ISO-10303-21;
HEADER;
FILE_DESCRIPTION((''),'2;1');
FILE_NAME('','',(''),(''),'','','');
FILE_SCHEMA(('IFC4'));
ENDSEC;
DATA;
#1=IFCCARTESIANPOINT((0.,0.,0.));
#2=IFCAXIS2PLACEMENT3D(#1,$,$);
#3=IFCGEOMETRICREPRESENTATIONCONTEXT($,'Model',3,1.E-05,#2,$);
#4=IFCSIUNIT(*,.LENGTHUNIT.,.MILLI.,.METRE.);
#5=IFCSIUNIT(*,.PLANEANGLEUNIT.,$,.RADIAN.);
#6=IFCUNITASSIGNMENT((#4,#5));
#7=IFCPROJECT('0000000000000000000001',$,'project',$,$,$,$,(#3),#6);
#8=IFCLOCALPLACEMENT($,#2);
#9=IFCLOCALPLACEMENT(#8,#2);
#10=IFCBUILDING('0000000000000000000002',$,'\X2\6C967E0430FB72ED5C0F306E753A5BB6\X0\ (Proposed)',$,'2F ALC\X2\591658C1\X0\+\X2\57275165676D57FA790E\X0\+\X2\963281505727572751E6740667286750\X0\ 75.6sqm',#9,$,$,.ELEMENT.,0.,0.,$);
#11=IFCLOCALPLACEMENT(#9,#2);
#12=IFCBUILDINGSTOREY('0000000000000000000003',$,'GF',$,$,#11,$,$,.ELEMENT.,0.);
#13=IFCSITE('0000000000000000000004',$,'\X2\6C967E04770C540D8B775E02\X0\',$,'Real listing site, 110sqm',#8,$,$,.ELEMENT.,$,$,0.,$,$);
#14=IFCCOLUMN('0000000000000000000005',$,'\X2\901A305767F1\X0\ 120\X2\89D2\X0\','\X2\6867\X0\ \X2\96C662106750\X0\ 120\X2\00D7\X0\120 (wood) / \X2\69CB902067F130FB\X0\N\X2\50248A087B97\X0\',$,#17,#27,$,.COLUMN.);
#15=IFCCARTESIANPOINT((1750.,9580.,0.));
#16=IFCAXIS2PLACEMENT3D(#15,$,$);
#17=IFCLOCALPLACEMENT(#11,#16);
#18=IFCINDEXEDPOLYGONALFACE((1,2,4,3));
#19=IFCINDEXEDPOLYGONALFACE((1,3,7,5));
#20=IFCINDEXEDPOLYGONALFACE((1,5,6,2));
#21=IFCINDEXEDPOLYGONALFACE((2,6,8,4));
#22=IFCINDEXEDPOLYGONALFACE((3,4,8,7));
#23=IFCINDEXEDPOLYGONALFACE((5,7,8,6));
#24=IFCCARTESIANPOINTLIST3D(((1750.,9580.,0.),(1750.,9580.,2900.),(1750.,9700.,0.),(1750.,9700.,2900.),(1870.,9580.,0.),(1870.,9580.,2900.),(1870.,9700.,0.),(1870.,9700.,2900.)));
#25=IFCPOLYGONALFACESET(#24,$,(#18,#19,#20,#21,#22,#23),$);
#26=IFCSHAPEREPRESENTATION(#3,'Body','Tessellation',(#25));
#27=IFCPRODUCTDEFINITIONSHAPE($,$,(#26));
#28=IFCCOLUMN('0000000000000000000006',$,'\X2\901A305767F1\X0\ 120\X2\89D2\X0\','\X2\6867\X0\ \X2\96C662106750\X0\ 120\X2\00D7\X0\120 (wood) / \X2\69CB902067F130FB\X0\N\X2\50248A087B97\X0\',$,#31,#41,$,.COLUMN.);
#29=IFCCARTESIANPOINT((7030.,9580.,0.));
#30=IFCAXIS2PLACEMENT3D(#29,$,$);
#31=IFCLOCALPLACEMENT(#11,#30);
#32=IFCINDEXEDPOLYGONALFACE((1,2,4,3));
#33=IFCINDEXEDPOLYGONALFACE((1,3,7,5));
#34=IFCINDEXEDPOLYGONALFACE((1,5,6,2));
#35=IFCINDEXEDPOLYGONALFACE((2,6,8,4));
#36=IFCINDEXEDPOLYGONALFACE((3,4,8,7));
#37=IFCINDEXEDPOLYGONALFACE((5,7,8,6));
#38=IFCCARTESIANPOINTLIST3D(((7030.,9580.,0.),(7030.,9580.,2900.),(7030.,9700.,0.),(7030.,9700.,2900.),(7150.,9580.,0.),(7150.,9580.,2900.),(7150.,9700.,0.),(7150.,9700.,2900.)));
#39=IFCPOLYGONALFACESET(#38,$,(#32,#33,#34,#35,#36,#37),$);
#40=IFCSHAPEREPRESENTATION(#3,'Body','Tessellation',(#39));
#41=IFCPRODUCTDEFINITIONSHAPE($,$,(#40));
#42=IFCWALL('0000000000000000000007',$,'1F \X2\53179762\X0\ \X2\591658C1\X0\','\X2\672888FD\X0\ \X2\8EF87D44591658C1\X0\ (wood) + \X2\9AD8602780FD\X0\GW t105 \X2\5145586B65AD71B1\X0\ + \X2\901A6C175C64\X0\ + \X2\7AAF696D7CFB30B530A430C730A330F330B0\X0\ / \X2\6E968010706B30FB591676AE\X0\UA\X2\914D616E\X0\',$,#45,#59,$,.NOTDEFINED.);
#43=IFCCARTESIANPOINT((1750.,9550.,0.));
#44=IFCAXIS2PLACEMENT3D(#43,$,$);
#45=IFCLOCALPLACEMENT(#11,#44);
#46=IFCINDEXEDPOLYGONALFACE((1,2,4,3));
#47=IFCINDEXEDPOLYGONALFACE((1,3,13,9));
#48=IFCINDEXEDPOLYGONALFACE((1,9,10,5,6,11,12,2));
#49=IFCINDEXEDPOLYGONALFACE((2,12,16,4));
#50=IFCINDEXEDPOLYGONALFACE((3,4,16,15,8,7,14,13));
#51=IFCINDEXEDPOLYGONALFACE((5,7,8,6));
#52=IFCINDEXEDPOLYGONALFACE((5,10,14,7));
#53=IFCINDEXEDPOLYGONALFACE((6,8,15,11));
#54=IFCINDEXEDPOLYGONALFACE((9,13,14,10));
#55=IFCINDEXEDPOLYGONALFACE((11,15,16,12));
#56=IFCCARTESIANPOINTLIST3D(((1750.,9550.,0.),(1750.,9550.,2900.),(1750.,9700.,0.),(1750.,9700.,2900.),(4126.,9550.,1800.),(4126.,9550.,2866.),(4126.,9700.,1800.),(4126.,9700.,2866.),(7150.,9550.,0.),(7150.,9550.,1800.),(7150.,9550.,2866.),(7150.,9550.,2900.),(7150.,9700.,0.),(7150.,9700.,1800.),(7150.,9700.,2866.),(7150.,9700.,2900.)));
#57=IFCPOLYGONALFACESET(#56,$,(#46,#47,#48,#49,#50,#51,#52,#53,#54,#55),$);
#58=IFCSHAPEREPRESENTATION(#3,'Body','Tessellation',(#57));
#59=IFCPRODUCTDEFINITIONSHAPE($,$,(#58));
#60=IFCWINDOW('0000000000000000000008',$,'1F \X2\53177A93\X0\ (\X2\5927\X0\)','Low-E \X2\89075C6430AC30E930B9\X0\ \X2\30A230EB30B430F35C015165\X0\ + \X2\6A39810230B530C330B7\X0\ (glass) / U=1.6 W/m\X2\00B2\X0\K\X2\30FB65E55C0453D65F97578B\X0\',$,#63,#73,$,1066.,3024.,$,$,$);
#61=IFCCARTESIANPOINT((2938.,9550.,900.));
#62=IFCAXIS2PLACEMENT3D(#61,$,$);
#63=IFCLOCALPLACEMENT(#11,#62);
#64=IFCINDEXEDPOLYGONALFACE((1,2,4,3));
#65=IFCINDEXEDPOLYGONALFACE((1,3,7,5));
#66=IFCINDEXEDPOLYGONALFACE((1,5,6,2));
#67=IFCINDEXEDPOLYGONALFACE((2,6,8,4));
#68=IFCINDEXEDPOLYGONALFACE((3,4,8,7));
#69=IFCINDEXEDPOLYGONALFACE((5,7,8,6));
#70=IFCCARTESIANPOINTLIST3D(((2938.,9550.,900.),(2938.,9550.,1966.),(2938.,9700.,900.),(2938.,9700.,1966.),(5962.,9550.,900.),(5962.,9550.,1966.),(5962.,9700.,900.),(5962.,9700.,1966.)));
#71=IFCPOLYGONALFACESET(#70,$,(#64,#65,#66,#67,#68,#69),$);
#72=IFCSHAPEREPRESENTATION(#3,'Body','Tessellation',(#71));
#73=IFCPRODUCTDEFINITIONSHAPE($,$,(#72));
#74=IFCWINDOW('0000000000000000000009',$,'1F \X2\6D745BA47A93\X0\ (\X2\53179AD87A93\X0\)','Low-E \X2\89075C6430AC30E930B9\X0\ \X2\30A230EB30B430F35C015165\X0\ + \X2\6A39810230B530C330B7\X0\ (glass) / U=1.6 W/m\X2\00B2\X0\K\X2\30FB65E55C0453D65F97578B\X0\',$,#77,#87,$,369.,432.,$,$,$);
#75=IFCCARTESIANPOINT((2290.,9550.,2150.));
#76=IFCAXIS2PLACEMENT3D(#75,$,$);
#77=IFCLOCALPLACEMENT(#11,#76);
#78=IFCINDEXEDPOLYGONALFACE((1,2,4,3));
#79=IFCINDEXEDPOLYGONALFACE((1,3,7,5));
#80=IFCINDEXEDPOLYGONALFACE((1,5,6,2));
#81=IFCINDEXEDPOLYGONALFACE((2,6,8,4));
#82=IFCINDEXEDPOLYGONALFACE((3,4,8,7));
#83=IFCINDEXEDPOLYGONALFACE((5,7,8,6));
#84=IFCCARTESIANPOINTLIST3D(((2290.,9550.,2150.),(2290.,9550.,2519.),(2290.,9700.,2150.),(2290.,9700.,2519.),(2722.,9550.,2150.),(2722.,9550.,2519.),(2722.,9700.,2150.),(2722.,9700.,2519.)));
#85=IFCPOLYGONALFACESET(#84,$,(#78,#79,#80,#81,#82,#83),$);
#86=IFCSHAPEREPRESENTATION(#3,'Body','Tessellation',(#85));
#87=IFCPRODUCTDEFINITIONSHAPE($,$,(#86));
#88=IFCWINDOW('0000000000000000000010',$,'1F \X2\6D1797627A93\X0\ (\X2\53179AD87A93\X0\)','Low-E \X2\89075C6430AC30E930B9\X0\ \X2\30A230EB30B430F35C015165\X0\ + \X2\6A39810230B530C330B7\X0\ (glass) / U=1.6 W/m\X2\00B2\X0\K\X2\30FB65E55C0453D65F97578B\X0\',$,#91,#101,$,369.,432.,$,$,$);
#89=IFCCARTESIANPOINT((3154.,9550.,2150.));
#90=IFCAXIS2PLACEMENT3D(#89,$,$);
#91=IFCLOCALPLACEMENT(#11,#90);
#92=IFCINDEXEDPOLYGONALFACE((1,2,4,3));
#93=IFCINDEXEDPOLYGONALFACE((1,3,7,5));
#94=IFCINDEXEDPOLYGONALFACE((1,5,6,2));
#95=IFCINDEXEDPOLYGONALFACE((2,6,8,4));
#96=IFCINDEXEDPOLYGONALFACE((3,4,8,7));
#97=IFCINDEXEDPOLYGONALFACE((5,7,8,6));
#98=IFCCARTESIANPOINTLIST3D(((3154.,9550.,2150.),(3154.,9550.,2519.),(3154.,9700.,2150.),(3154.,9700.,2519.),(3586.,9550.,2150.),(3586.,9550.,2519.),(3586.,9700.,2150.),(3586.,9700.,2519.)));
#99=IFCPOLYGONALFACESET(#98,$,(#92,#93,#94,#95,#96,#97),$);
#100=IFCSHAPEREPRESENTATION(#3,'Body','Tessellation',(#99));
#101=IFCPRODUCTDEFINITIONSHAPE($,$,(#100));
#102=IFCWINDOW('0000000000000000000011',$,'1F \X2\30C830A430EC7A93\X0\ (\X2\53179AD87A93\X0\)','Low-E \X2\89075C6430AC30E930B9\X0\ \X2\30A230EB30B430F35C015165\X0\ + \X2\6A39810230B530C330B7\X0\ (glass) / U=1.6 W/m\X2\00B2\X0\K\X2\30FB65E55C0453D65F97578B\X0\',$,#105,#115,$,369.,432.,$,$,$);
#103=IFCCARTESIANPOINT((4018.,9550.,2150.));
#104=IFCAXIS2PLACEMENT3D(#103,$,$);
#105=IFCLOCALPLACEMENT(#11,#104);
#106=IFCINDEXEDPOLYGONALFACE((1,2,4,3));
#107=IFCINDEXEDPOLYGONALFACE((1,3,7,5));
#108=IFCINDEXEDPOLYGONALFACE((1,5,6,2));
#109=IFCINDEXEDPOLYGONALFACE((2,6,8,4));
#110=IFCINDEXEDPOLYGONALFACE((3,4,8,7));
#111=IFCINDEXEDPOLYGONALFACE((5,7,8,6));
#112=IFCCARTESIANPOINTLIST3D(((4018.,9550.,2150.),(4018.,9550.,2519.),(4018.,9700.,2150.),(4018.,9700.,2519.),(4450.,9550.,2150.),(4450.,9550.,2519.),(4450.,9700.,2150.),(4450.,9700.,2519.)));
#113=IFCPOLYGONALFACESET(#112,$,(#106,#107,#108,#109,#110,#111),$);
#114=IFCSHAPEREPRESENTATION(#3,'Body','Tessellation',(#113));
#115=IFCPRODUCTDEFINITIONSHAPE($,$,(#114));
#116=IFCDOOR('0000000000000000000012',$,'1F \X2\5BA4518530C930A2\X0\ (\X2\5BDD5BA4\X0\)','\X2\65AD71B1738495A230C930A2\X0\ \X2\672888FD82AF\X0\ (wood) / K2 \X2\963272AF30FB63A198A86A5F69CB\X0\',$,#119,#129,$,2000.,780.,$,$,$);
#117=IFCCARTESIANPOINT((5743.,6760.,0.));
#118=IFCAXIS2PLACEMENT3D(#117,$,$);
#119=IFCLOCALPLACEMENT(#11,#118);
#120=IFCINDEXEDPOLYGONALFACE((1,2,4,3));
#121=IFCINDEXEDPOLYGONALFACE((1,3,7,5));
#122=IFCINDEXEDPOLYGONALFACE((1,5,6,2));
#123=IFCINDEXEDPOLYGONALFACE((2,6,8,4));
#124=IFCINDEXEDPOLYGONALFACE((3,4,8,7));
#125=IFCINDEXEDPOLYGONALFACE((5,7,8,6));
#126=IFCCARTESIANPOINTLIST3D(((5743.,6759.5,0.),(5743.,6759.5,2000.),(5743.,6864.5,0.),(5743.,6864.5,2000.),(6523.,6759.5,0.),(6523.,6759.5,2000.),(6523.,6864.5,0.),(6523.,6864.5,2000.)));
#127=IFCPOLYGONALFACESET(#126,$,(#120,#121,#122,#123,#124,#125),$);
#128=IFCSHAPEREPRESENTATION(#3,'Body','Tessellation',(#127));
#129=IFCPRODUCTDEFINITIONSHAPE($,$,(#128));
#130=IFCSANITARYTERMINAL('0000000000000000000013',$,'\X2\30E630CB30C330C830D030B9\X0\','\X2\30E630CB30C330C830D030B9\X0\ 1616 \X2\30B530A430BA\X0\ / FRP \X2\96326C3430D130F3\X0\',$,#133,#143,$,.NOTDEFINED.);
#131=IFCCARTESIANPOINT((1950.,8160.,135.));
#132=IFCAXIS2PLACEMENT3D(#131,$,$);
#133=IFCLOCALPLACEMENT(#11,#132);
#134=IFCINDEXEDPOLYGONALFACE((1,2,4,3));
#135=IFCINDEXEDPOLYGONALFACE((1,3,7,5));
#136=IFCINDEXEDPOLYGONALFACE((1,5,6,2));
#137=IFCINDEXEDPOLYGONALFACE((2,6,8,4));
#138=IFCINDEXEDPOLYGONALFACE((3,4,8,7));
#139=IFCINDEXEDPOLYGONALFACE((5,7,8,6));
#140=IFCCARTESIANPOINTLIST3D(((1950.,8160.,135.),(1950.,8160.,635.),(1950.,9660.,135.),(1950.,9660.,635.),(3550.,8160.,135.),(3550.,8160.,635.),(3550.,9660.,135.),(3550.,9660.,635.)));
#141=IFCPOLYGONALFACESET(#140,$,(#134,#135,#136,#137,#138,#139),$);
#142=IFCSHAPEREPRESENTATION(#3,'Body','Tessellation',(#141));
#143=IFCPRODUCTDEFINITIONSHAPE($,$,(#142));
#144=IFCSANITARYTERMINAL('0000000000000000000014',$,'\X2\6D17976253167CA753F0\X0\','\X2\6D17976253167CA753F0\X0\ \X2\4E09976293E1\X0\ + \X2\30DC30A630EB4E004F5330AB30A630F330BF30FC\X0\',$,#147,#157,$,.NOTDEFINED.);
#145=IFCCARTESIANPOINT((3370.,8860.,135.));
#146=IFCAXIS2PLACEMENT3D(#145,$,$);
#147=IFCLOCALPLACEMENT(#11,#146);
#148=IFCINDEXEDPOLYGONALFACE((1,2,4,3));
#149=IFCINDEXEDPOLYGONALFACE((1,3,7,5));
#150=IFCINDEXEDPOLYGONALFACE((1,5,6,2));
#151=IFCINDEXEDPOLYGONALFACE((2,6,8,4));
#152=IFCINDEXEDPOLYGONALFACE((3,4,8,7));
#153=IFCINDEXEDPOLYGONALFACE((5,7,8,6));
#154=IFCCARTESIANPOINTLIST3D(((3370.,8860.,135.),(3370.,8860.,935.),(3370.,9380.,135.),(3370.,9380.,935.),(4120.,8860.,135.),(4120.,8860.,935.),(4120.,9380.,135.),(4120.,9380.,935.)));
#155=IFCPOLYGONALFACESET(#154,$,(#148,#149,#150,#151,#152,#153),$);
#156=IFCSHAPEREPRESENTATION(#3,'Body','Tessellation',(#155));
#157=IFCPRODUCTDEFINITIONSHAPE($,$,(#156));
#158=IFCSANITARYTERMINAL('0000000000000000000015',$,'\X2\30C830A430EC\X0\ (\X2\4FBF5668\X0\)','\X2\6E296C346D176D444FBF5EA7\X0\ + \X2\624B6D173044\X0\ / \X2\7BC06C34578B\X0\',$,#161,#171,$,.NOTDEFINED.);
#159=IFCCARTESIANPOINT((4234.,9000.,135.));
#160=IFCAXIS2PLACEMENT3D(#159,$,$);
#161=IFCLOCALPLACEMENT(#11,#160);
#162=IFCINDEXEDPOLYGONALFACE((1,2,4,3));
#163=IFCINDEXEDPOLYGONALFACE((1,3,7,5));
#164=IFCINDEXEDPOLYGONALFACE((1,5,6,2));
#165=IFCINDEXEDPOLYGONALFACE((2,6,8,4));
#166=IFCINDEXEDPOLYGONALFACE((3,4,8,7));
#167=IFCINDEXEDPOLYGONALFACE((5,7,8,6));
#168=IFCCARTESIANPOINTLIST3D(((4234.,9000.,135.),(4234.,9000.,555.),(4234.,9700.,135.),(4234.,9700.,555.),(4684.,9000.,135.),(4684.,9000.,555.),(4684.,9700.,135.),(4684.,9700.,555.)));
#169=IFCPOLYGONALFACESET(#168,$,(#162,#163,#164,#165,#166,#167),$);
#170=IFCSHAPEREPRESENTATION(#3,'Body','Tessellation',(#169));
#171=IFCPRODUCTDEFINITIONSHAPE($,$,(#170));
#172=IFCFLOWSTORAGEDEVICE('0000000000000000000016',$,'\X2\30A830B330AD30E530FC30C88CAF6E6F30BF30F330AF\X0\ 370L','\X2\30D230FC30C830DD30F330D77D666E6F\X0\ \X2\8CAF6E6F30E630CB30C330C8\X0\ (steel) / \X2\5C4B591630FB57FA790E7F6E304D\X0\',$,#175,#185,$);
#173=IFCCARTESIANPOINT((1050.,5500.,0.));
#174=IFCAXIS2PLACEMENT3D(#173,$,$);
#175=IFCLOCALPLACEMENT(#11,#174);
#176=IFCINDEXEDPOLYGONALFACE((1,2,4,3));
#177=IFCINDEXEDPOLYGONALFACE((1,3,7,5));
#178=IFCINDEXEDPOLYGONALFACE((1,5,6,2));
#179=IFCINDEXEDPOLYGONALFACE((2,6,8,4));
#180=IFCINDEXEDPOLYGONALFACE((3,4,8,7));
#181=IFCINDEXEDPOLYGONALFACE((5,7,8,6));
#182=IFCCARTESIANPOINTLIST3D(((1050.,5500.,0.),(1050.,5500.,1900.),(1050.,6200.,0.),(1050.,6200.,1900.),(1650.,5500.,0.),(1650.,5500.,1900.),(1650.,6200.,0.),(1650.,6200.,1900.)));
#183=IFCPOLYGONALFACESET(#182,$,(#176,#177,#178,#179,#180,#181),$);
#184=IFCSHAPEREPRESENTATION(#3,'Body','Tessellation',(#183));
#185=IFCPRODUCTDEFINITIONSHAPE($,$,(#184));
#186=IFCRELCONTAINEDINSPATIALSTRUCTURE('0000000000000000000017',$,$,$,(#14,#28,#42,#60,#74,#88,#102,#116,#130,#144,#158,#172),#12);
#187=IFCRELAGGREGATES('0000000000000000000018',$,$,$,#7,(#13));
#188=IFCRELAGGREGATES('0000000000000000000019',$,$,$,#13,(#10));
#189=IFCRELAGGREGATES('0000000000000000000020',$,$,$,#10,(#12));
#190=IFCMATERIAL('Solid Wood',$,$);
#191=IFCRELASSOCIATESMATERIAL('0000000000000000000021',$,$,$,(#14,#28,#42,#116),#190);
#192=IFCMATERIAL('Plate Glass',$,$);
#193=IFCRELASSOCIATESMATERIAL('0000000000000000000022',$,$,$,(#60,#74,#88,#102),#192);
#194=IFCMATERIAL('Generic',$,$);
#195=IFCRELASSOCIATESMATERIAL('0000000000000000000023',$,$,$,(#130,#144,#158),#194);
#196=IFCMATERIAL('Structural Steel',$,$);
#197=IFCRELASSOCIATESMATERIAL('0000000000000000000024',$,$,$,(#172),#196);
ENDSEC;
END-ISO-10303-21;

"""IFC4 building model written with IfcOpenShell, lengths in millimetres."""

from ifc_helpers import new_model, si_unit, frame, frame_2d, origin, place, context, project, spatial, rectangle, extrude, material, element, fill, save


model = new_model("IFC4")

# Units and contexts
model_context = context("Model", 3, precision=1e-05, world=origin())
ifc_project = project(units=[si_unit("LENGTHUNIT", "METRE", prefix="MILLI"), si_unit("PLANEANGLEUNIT", "RADIAN")], contexts=[model_context])

# Site, building, storey
site_placement = place(None, origin())
site = spatial("IfcSite", under=ifc_project, at=site_placement, Name="沖縄県名護市", ObjectType="Real listing site, 110sqm", CompositionType="ELEMENT", RefElevation=0.0)
building_placement = place(site_placement, origin())
building = spatial("IfcBuilding", under=site, at=building_placement, Name="沖縄・狭小の町家 (Proposed)", ObjectType="2F ALC外壁+圧入杭基礎+防腐圧圧処理木材 75.6sqm", CompositionType="ELEMENT", ElevationOfRefHeight=0.0, ElevationOfTerrain=0.0)
storey_placement = place(building_placement, origin())
storey = spatial("IfcBuildingStorey", under=building, at=storey_placement, Name="GF", CompositionType="ELEMENT", Elevation=0.0)

# Columns
ifc_material_1 = material(Name="Solid Wood")
column_1_placement = place(storey_placement, frame((1750.0, 9580.0, 0.0)))
element("IfcColumn", 1, at=column_1_placement, inside=storey, material=ifc_material_1, Name="通し柱 120角", Description="桧 集成材 120×120 (wood) / 構造柱・N値計算", PredefinedType="COLUMN", context=model_context, shape_type="SweptSolid", body=[
    extrude(rectangle(XDim=120.0, YDim=120.0, at=frame_2d((60.0, 60.0))), frame((1750.0, 9580.0, 0.0)), (0.0, 0.0, 1.0), 2900.0),
])
column_2_placement = place(storey_placement, frame((7030.0, 9580.0, 0.0)))
element("IfcColumn", 2, at=column_2_placement, inside=storey, material=ifc_material_1, Name="通し柱 120角", Description="桧 集成材 120×120 (wood) / 構造柱・N値計算", PredefinedType="COLUMN", context=model_context, shape_type="SweptSolid", body=[
    extrude(rectangle(XDim=120.0, YDim=120.0, at=frame_2d((60.0, 60.0))), frame((7030.0, 9580.0, 0.0)), (0.0, 0.0, 1.0), 2900.0),
])

# Wall, openings, windows
wall_1_placement = place(storey_placement, frame((1750.0, 9550.0, 0.0)))
wall_1 = element("IfcWall", 3, at=wall_1_placement, inside=storey, material=ifc_material_1, Name="1F 北面 外壁", Description="木製 軸組外壁 (wood) + 高性能GW t105 充填断熱 + 通気層 + 窯業系サイディング / 準耐火・外皮UA配慮", PredefinedType="NOTDEFINED", context=model_context, shape_type="SweptSolid", body=[
    extrude(rectangle(XDim=5400.0, YDim=150.0, at=frame_2d((2700.0, 75.0))), frame((1750.0, 9550.0, 0.0)), (0.0, 0.0, 1.0), 2900.0),
])
opening_1_placement = place(storey_placement, frame((2938.0, 9550.0, 900.0)))
opening_1 = element("IfcOpeningElement", 4, at=opening_1_placement, cuts=wall_1, PredefinedType="NOTDEFINED", context=model_context, shape_type="SweptSolid", body=[
    extrude(rectangle(XDim=3024.0, YDim=150.0, at=frame_2d((1512.0, 75.0))), frame((2938.0, 9550.0, 900.0)), (0.0, 0.0, 1.0), 1066.0),
])
opening_2_placement = place(storey_placement, frame((2290.0, 9550.0, 2150.0)))
opening_2 = element("IfcOpeningElement", 5, at=opening_2_placement, cuts=wall_1, PredefinedType="NOTDEFINED", context=model_context, shape_type="SweptSolid", body=[
    extrude(rectangle(XDim=432.0, YDim=150.0, at=frame_2d((216.0, 75.0))), frame((2290.0, 9550.0, 2150.0)), (0.0, 0.0, 1.0), 369.0),
])
opening_3_placement = place(storey_placement, frame((3154.0, 9550.0, 2150.0)))
opening_3 = element("IfcOpeningElement", 6, at=opening_3_placement, cuts=wall_1, PredefinedType="NOTDEFINED", context=model_context, shape_type="SweptSolid", body=[
    extrude(rectangle(XDim=432.0, YDim=150.0, at=frame_2d((216.0, 75.0))), frame((3154.0, 9550.0, 2150.0)), (0.0, 0.0, 1.0), 369.0),
])
opening_4_placement = place(storey_placement, frame((4018.0, 9550.0, 2150.0)))
opening_4 = element("IfcOpeningElement", 7, at=opening_4_placement, cuts=wall_1, PredefinedType="NOTDEFINED", context=model_context, shape_type="SweptSolid", body=[
    extrude(rectangle(XDim=432.0, YDim=150.0, at=frame_2d((216.0, 75.0))), frame((4018.0, 9550.0, 2150.0)), (0.0, 0.0, 1.0), 369.0),
])
ifc_material_2 = material(Name="Plate Glass")
window_1_placement = place(storey_placement, frame((2938.0, 9550.0, 900.0)))
window_1 = element("IfcWindow", 8, at=window_1_placement, inside=storey, material=ifc_material_2, Name="1F 北窓 (大)", Description="Low-E 複層ガラス アルゴン封入 + 樹脂サッシ (glass) / U=1.6 W/m²K・日射取得型", OverallHeight=1066.0, OverallWidth=3024.0, context=model_context, shape_type="SweptSolid", body=[
    extrude(rectangle(XDim=3024.0, YDim=150.0, at=frame_2d((1512.0, 75.0))), frame((2938.0, 9550.0, 900.0)), (0.0, 0.0, 1.0), 1066.0),
])
fill(opening_1, window_1)
window_2_placement = place(storey_placement, frame((2290.0, 9550.0, 2150.0)))
window_2 = element("IfcWindow", 9, at=window_2_placement, inside=storey, material=ifc_material_2, Name="1F 浴室窓 (北高窓)", Description="Low-E 複層ガラス アルゴン封入 + 樹脂サッシ (glass) / U=1.6 W/m²K・日射取得型", OverallHeight=369.0, OverallWidth=432.0, context=model_context, shape_type="SweptSolid", body=[
    extrude(rectangle(XDim=432.0, YDim=150.0, at=frame_2d((216.0, 75.0))), frame((2290.0, 9550.0, 2150.0)), (0.0, 0.0, 1.0), 369.0),
])
fill(opening_2, window_2)
window_3_placement = place(storey_placement, frame((3154.0, 9550.0, 2150.0)))
window_3 = element("IfcWindow", 10, at=window_3_placement, inside=storey, material=ifc_material_2, Name="1F 洗面窓 (北高窓)", Description="Low-E 複層ガラス アルゴン封入 + 樹脂サッシ (glass) / U=1.6 W/m²K・日射取得型", OverallHeight=369.0, OverallWidth=432.0, context=model_context, shape_type="SweptSolid", body=[
    extrude(rectangle(XDim=432.0, YDim=150.0, at=frame_2d((216.0, 75.0))), frame((3154.0, 9550.0, 2150.0)), (0.0, 0.0, 1.0), 369.0),
])
fill(opening_3, window_3)
window_4_placement = place(storey_placement, frame((4018.0, 9550.0, 2150.0)))
window_4 = element("IfcWindow", 11, at=window_4_placement, inside=storey, material=ifc_material_2, Name="1F トイレ窓 (北高窓)", Description="Low-E 複層ガラス アルゴン封入 + 樹脂サッシ (glass) / U=1.6 W/m²K・日射取得型", OverallHeight=369.0, OverallWidth=432.0, context=model_context, shape_type="SweptSolid", body=[
    extrude(rectangle(XDim=432.0, YDim=150.0, at=frame_2d((216.0, 75.0))), frame((4018.0, 9550.0, 2150.0)), (0.0, 0.0, 1.0), 369.0),
])
fill(opening_4, window_4)

# Door
door_1_placement = place(storey_placement, frame((5743.0, 6760.0, 0.0)))
element("IfcDoor", 12, at=door_1_placement, inside=storey, material=ifc_material_1, Name="1F 室内ドア (寝室)", Description="断熱玄関ドア 木製芯 (wood) / K2 防犯・採風機構", OverallHeight=2000.0, OverallWidth=780.0, context=model_context, shape_type="SweptSolid", body=[
    extrude(rectangle(XDim=780.0, YDim=105.0, at=frame_2d((390.0, 52.0))), frame((5743.0, 6760.0, 0.0)), (0.0, 0.0, 1.0), 2000.0),
])

# Sanitary terminals
ifc_material_3 = material(Name="Generic")
sanitary_terminal_1_placement = place(storey_placement, frame((1950.0, 8160.0, 135.0)))
element("IfcSanitaryTerminal", 13, at=sanitary_terminal_1_placement, inside=storey, material=ifc_material_3, Name="ユニットバス", Description="ユニットバス 1616 サイズ / FRP 防水パン", PredefinedType="NOTDEFINED", context=model_context, shape_type="SweptSolid", body=[
    extrude(rectangle(XDim=1600.0, YDim=1500.0, at=frame_2d((800.0, 750.0))), frame((1950.0, 8160.0, 135.0)), (0.0, 0.0, 1.0), 500.0),
])
sanitary_terminal_2_placement = place(storey_placement, frame((3370.0, 8860.0, 135.0)))
element("IfcSanitaryTerminal", 14, at=sanitary_terminal_2_placement, inside=storey, material=ifc_material_3, Name="洗面化粧台", Description="洗面化粧台 三面鏡 + ボウル一体カウンター", PredefinedType="NOTDEFINED", context=model_context, shape_type="SweptSolid", body=[
    extrude(rectangle(XDim=750.0, YDim=520.0, at=frame_2d((375.0, 260.0))), frame((3370.0, 8860.0, 135.0)), (0.0, 0.0, 1.0), 800.0),
])
sanitary_terminal_3_placement = place(storey_placement, frame((4234.0, 9000.0, 135.0)))
element("IfcSanitaryTerminal", 15, at=sanitary_terminal_3_placement, inside=storey, material=ifc_material_3, Name="トイレ (便器)", Description="温水洗浄便座 + 手洗い / 節水型", PredefinedType="NOTDEFINED", context=model_context, shape_type="SweptSolid", body=[
    extrude(rectangle(XDim=450.0, YDim=700.0, at=frame_2d((225.0, 350.0))), frame((4234.0, 9000.0, 135.0)), (0.0, 0.0, 1.0), 420.0),
])

# Flow storage device
ifc_material_4 = material(Name="Structural Steel")
flow_storage_device_placement = place(storey_placement, frame((1050.0, 5500.0, 0.0)))
element("IfcFlowStorageDevice", 16, at=flow_storage_device_placement, inside=storey, material=ifc_material_4, Name="エコキュート貯湯タンク 370L", Description="ヒートポンプ給湯 貯湯ユニット (steel) / 屋外・基礎置き", context=model_context, shape_type="SweptSolid", body=[
    extrude(rectangle(XDim=600.0, YDim=700.0, at=frame_2d((300.0, 350.0))), frame((1050.0, 5500.0, 0.0)), (0.0, 0.0, 1.0), 1900.0),
])

save(model, "model.ifc")
